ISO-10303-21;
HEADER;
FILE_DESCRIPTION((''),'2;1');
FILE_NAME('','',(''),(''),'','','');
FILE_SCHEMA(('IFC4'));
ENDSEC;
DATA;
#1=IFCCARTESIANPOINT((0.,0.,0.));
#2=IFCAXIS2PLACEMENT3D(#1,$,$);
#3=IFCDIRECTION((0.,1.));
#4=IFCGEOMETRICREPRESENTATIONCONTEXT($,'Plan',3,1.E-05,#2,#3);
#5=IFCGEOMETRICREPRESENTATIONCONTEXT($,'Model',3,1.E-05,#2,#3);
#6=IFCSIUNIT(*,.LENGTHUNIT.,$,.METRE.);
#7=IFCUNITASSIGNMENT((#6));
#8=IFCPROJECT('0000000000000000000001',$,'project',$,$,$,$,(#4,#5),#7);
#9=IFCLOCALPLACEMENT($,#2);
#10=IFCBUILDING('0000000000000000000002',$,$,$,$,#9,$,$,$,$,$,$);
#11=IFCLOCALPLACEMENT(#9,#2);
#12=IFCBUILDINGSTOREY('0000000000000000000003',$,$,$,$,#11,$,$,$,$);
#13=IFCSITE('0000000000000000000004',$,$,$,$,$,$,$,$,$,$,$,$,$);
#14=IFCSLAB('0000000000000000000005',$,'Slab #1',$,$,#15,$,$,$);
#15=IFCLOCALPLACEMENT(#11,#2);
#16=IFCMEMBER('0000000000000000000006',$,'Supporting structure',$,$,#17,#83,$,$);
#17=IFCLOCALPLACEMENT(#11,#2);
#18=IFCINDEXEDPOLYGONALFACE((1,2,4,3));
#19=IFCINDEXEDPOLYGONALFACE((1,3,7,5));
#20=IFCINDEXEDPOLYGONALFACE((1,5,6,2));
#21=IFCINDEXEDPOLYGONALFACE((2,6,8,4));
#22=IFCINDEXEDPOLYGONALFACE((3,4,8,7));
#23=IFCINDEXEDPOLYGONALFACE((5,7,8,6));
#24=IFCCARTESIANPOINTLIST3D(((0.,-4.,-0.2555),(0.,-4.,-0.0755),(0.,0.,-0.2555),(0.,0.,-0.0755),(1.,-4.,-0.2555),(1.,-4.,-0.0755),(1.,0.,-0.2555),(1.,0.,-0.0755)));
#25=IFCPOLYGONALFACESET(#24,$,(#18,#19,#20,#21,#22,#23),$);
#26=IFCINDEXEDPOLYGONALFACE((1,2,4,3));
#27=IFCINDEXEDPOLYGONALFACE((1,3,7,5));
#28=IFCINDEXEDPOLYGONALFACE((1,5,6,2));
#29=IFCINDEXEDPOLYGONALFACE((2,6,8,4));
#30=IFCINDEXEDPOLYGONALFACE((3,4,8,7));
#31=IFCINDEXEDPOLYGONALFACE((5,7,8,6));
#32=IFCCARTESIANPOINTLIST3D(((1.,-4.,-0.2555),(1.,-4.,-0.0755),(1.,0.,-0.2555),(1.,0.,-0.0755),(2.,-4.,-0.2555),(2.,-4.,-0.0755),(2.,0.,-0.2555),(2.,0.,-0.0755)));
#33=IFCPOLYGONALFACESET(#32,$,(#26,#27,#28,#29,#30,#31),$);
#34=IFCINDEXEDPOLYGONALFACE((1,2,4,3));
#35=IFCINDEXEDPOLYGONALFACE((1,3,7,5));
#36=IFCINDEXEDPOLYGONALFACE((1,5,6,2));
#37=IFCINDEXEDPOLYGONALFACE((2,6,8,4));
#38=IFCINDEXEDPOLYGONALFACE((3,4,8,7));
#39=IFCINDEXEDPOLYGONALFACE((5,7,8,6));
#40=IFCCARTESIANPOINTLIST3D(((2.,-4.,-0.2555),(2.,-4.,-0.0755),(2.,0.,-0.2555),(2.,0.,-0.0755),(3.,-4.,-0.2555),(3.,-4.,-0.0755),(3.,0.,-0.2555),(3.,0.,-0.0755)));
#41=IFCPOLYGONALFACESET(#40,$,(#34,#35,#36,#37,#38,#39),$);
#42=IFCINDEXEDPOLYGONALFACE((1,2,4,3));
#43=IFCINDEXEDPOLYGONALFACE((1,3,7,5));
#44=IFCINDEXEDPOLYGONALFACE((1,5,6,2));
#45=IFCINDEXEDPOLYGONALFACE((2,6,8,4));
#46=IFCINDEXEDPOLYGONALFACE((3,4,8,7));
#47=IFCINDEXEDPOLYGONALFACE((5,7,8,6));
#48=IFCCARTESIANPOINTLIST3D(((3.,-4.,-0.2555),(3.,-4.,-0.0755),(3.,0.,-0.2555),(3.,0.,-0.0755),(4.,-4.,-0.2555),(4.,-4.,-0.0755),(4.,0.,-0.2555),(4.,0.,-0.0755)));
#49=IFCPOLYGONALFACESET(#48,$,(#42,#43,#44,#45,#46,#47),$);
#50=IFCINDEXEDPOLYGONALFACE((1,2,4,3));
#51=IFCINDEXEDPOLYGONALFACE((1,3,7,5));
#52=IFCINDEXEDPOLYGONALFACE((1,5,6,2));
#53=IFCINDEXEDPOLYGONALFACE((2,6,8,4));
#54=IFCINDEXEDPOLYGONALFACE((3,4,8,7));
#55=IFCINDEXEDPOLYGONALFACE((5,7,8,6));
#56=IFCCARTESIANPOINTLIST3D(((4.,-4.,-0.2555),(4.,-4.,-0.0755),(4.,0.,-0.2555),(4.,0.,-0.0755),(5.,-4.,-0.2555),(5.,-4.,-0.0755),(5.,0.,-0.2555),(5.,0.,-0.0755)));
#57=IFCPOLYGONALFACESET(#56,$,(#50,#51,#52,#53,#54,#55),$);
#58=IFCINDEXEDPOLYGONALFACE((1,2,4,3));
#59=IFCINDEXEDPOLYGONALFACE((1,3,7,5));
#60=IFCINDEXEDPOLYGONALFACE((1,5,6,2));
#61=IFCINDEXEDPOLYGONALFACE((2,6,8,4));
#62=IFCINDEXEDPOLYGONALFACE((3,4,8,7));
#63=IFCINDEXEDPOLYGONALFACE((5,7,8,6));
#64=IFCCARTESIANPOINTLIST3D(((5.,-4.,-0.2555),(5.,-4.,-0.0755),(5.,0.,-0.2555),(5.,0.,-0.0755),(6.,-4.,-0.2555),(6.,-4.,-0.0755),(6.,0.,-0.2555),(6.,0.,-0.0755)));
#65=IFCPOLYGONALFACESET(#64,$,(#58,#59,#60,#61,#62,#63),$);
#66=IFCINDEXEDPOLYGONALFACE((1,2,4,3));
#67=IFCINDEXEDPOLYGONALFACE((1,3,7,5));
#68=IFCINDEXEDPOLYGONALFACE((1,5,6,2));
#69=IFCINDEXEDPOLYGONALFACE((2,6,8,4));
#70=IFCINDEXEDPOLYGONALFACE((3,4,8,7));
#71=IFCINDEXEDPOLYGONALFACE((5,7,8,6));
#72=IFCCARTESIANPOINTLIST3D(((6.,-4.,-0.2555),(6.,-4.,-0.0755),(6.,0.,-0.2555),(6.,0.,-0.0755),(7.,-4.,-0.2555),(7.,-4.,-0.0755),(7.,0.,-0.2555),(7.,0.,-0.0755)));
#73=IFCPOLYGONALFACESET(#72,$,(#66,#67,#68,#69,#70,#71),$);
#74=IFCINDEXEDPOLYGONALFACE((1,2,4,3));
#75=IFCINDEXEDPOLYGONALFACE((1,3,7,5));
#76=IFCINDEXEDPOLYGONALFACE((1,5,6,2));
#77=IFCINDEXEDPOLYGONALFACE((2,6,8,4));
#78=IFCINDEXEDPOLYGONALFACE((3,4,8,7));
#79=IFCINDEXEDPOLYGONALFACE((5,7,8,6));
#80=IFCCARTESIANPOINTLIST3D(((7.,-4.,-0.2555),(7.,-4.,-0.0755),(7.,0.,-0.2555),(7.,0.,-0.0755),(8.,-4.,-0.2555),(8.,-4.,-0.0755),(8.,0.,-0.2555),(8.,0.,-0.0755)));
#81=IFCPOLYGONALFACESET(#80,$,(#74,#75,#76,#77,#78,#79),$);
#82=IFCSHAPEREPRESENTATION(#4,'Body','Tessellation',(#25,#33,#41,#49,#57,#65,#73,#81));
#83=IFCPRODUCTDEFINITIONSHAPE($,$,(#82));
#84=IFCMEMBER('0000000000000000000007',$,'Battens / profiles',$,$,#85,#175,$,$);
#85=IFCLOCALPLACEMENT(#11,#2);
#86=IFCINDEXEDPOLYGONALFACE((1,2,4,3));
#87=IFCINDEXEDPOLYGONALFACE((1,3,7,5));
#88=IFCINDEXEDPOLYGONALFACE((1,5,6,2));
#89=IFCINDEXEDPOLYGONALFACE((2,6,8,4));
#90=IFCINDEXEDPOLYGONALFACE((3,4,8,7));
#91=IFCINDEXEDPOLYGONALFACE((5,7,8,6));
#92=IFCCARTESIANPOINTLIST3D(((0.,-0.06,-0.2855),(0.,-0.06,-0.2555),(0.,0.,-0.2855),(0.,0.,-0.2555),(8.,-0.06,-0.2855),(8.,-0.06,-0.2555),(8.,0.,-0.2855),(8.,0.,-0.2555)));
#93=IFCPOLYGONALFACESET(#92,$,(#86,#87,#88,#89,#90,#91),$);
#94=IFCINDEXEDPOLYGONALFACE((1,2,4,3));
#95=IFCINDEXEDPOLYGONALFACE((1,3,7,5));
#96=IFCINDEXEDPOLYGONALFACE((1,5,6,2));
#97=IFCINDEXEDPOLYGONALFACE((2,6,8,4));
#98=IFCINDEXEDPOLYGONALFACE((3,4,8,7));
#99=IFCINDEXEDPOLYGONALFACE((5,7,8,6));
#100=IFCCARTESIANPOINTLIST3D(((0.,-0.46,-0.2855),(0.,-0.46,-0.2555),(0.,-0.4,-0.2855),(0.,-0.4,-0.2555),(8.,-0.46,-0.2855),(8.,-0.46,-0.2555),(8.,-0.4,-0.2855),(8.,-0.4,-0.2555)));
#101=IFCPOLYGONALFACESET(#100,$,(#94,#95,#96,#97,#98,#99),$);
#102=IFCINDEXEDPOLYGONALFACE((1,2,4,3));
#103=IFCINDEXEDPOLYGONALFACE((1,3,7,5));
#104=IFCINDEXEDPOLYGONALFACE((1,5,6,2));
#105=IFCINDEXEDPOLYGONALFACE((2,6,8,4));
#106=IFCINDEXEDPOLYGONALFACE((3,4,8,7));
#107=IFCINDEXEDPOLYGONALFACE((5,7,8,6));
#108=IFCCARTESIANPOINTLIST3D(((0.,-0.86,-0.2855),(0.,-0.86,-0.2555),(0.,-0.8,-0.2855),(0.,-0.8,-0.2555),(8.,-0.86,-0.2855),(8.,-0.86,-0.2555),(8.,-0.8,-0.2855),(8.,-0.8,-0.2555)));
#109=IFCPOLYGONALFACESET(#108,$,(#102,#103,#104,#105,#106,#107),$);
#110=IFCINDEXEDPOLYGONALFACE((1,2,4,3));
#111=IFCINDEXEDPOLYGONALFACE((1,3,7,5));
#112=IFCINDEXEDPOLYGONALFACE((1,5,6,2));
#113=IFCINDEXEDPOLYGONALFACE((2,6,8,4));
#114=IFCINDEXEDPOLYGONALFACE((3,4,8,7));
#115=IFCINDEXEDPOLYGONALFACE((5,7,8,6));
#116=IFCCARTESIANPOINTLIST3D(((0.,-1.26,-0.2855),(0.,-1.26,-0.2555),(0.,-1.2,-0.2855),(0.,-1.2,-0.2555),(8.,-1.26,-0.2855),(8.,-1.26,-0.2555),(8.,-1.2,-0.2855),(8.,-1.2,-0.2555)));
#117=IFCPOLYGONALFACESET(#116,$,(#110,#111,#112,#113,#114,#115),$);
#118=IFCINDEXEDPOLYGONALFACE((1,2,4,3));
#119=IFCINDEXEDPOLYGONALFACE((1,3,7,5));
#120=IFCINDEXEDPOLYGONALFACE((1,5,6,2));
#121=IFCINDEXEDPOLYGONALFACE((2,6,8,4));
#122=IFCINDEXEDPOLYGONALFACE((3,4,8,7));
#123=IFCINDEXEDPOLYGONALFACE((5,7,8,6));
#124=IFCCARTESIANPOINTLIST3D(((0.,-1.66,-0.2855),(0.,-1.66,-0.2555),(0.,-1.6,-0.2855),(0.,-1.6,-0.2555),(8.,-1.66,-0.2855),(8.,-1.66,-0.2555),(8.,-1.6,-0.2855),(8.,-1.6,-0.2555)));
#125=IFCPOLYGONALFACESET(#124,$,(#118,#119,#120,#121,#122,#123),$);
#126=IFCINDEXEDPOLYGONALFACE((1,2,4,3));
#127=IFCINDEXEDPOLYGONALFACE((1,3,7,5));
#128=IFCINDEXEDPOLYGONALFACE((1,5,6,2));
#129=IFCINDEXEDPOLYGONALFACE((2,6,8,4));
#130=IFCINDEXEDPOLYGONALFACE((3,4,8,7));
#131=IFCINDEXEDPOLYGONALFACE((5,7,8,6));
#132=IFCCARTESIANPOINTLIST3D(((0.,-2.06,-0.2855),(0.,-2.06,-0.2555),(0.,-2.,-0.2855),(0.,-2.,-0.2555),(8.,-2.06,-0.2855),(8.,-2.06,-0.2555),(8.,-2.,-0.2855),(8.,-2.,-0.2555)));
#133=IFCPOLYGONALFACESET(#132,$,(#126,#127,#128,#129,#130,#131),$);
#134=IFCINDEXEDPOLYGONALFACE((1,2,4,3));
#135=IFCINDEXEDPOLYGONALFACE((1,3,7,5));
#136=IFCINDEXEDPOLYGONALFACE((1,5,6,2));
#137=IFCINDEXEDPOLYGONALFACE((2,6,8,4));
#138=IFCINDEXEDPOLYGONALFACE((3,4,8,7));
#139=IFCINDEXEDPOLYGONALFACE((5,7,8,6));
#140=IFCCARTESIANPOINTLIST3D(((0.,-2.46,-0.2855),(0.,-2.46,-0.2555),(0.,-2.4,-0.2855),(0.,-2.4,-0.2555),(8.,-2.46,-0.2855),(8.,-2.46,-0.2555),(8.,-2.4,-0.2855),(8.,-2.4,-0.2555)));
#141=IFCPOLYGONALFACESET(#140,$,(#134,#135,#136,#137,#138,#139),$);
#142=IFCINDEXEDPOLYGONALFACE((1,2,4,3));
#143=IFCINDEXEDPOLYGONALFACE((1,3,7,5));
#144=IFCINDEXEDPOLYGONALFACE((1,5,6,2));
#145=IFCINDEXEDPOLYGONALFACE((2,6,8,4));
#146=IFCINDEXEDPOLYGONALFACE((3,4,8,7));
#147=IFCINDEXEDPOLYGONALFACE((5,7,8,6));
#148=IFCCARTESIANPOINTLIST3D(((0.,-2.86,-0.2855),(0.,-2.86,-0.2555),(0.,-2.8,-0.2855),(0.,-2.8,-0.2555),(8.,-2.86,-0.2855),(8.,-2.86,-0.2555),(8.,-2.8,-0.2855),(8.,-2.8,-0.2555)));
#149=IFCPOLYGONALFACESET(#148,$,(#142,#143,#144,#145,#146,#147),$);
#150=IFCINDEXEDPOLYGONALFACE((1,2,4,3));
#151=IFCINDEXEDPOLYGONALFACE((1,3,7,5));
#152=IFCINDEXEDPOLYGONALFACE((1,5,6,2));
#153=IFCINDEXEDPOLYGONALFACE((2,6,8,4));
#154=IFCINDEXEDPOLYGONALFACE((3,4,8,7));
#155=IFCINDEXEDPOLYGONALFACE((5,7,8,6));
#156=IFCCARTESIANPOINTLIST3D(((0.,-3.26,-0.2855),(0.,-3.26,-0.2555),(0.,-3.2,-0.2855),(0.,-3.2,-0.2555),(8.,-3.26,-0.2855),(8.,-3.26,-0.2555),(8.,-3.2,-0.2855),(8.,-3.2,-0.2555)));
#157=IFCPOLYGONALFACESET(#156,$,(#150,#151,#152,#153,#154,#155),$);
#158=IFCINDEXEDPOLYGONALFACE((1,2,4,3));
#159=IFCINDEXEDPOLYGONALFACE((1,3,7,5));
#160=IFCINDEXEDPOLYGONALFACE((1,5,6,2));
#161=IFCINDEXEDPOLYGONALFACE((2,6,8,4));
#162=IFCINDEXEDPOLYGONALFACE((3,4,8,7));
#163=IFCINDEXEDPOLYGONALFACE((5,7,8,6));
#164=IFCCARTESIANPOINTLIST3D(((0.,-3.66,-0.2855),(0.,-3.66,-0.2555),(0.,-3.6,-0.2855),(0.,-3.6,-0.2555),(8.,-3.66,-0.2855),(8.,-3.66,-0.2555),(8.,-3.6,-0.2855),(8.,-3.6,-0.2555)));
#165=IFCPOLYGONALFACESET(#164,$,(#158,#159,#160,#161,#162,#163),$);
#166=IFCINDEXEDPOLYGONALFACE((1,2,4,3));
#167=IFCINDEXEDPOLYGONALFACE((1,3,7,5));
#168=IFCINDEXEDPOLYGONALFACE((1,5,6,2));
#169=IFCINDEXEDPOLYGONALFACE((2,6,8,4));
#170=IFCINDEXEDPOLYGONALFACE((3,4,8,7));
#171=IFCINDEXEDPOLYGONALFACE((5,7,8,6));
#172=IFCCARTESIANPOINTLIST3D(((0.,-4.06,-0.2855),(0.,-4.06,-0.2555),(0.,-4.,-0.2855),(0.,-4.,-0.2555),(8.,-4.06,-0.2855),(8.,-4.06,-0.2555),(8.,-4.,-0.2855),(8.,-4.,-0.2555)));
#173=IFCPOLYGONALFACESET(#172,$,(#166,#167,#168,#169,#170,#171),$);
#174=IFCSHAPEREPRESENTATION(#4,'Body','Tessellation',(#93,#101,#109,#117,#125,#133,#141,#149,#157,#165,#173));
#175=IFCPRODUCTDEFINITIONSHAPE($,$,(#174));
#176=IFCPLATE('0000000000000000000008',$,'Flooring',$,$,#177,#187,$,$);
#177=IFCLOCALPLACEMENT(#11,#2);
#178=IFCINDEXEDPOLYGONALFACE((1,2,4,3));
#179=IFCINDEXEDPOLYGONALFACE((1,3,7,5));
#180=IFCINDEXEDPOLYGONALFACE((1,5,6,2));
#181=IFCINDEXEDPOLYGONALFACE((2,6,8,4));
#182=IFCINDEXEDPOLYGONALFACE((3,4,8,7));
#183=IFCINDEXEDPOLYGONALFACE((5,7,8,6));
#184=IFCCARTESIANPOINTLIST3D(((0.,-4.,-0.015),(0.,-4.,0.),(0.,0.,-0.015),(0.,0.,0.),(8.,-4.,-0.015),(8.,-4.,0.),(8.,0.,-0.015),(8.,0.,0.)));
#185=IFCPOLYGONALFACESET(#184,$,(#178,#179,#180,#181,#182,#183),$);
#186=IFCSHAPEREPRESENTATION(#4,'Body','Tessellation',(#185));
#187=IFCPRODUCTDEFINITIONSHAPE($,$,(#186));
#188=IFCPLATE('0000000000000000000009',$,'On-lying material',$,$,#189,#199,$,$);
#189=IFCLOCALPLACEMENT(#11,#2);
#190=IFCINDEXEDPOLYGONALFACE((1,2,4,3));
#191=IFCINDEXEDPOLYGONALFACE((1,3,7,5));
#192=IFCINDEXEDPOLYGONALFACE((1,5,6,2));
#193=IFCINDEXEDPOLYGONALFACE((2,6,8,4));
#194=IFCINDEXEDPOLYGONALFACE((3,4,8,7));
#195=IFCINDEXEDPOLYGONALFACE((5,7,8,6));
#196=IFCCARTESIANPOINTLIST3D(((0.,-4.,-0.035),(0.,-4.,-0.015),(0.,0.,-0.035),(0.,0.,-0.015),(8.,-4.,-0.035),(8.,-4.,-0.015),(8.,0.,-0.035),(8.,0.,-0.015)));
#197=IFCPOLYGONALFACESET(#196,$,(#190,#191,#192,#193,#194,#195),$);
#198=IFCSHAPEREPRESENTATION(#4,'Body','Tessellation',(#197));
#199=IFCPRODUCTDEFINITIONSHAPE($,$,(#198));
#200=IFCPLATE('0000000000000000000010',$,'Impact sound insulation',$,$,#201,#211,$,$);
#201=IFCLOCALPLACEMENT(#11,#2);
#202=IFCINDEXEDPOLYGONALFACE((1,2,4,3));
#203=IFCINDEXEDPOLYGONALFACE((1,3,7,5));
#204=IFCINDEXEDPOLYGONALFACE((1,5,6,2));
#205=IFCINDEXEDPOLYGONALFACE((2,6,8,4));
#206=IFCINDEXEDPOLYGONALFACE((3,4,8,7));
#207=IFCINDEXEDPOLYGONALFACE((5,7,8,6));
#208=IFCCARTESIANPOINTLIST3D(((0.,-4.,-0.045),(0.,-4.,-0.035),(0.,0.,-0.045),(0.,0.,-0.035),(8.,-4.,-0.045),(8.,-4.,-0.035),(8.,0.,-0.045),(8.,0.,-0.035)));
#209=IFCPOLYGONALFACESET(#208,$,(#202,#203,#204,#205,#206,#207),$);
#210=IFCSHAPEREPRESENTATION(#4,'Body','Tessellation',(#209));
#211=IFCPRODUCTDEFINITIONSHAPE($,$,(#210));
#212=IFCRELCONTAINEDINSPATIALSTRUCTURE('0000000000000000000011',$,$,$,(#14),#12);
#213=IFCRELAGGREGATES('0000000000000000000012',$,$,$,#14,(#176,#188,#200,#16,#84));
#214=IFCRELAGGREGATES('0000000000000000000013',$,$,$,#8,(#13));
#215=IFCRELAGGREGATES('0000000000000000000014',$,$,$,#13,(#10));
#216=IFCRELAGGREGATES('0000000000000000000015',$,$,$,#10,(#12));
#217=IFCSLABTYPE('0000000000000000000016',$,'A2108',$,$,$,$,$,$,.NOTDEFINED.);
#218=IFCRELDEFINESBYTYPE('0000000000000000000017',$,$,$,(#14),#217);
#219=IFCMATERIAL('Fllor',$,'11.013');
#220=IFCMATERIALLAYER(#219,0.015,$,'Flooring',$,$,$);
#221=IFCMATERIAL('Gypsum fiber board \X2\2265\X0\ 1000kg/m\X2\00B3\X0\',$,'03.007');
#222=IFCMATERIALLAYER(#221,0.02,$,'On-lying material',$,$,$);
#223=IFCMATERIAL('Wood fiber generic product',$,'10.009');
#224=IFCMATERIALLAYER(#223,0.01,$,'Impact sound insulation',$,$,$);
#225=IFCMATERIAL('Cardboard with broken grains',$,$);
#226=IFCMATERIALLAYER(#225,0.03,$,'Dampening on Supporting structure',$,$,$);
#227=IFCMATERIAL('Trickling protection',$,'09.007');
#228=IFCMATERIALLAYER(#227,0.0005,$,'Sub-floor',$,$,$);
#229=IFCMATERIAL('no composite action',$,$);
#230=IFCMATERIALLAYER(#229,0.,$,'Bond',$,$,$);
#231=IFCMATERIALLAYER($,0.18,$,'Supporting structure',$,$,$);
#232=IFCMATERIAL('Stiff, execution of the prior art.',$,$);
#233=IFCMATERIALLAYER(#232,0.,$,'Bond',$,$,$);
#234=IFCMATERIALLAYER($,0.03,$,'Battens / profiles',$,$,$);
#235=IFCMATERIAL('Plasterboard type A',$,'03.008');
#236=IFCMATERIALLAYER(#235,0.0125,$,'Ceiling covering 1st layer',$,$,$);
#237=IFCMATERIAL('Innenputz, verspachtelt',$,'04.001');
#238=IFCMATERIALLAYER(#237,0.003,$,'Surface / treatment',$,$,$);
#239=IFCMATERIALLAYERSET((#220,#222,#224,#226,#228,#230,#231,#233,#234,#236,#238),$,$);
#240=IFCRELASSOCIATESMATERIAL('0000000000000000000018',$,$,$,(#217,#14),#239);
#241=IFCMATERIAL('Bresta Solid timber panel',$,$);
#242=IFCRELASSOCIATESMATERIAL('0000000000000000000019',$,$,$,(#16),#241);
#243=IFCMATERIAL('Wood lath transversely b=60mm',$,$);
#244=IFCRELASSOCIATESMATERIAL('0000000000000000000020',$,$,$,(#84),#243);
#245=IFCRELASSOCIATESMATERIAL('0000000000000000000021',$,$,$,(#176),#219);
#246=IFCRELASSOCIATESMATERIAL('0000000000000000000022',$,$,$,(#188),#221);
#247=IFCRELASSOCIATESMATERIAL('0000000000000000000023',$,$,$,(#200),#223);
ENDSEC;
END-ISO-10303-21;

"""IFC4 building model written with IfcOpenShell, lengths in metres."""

from ifc_helpers import new_model, si_unit, direction, frame, frame_2d, origin, origin_with_axes, place, context, project, spatial, rectangle, extrude, material, layer, layer_set, type_object, element, aggregate, save


model = new_model("IFC4")

# Units and contexts
plan_context = context("Plan", 3, precision=1e-05, world=origin(), true_north=direction((0.0, 1.0)))
model_context = context("Model", 3, precision=1e-05, world=origin(), true_north=direction((0.0, 1.0)))
ifc_project = project(units=[si_unit("LENGTHUNIT", "METRE")], contexts=[plan_context, model_context])

# Site, building, storey
site = spatial("IfcSite", under=ifc_project)
building_placement = place(None, origin())
building = spatial("IfcBuilding", under=site, at=building_placement)
storey_placement = place(building_placement, origin())
storey = spatial("IfcBuildingStorey", under=building, at=storey_placement)

# Slab, members, plates
ifc_material_1 = material(Name="Fllor", Category="11.013")
ifc_layer_1 = layer(ifc_material_1, 0.015, Name="Flooring")
ifc_material_2 = material(Name="Gypsum fiber board ≥ 1000kg/m³", Category="03.007")
ifc_layer_2 = layer(ifc_material_2, 0.02, Name="On-lying material")
ifc_material_3 = material(Name="Wood fiber generic product", Category="10.009")
ifc_layer_3 = layer(ifc_material_3, 0.01, Name="Impact sound insulation")
ifc_material_4 = material(Name="Cardboard with broken grains")
ifc_layer_4 = layer(ifc_material_4, 0.03, Name="Dampening on Supporting structure")
ifc_material_5 = material(Name="Trickling protection", Category="09.007")
ifc_layer_5 = layer(ifc_material_5, 0.0005, Name="Sub-floor")
ifc_material_6 = material(Name="no composite action")
ifc_layer_6 = layer(ifc_material_6, 0.0, Name="Bond")
ifc_layer_7 = layer(None, 0.18, Name="Supporting structure")
ifc_material_7 = material(Name="Stiff, execution of the prior art.")
ifc_layer_8 = layer(ifc_material_7, 0.0, Name="Bond")
ifc_layer_9 = layer(None, 0.03, Name="Battens / profiles")
ifc_material_8 = material(Name="Plasterboard type A", Category="03.008")
ifc_layer_10 = layer(ifc_material_8, 0.0125, Name="Ceiling covering 1st layer")
ifc_material_9 = material(Name="Innenputz, verspachtelt", Category="04.001")
ifc_layer_11 = layer(ifc_material_9, 0.003, Name="Surface / treatment")
ifc_layer_set = layer_set([ifc_layer_1, ifc_layer_2, ifc_layer_3, ifc_layer_4, ifc_layer_5, ifc_layer_6, ifc_layer_7, ifc_layer_8, ifc_layer_9, ifc_layer_10, ifc_layer_11])
slab_type = type_object("IfcSlabType", Name="A2108", PredefinedType="NOTDEFINED", material=ifc_layer_set)
slab_placement = place(None, frame((0.0, 0.0, 0.0), z_axis=(0.0, 0.0, -1.0), x_axis=(1.0, 0.0, 0.0)))
slab = element("IfcSlab", 1, at=slab_placement, inside=storey, type_object=slab_type, material=ifc_layer_set, Name="Slab #1")
ifc_material_10 = material(Name="Bresta Solid timber panel")
member_1_placement = place(slab_placement, origin())
member_1 = element("IfcMember", 2, at=member_1_placement, material=ifc_material_10, Name="Supporting structure", context=plan_context, shape_type="SweptSolid", body=[
    extrude(rectangle(XDim=1.0, YDim=0.18, at=frame_2d((0.5, 0.09), x_axis=(1.0, 0.0))), frame((0.0, 4.0, 0.0755), z_axis=(0.0, -1.0, 0.0), x_axis=(1.0, 0.0, 0.0)), (0.0, 0.0, 1.0), 4.0),
    extrude(rectangle(XDim=1.0, YDim=0.18, at=frame_2d((0.5, 0.09), x_axis=(1.0, 0.0))), frame((1.0, 4.0, 0.0755), z_axis=(0.0, -1.0, 0.0), x_axis=(1.0, 0.0, 0.0)), (0.0, 0.0, 1.0), 4.0),
    extrude(rectangle(XDim=1.0, YDim=0.18, at=frame_2d((0.5, 0.09), x_axis=(1.0, 0.0))), frame((2.0, 4.0, 0.0755), z_axis=(0.0, -1.0, 0.0), x_axis=(1.0, 0.0, 0.0)), (0.0, 0.0, 1.0), 4.0),
    extrude(rectangle(XDim=1.0, YDim=0.18, at=frame_2d((0.5, 0.09), x_axis=(1.0, 0.0))), frame((3.0, 4.0, 0.0755), z_axis=(0.0, -1.0, 0.0), x_axis=(1.0, 0.0, 0.0)), (0.0, 0.0, 1.0), 4.0),
    extrude(rectangle(XDim=1.0, YDim=0.18, at=frame_2d((0.5, 0.09), x_axis=(1.0, 0.0))), frame((4.0, 4.0, 0.0755), z_axis=(0.0, -1.0, 0.0), x_axis=(1.0, 0.0, 0.0)), (0.0, 0.0, 1.0), 4.0),
    extrude(rectangle(XDim=1.0, YDim=0.18, at=frame_2d((0.5, 0.09), x_axis=(1.0, 0.0))), frame((5.0, 4.0, 0.0755), z_axis=(0.0, -1.0, 0.0), x_axis=(1.0, 0.0, 0.0)), (0.0, 0.0, 1.0), 4.0),
    extrude(rectangle(XDim=1.0, YDim=0.18, at=frame_2d((0.5, 0.09), x_axis=(1.0, 0.0))), frame((6.0, 4.0, 0.0755), z_axis=(0.0, -1.0, 0.0), x_axis=(1.0, 0.0, 0.0)), (0.0, 0.0, 1.0), 4.0),
    extrude(rectangle(XDim=1.0, YDim=0.18, at=frame_2d((0.5, 0.09), x_axis=(1.0, 0.0))), frame((7.0, 4.0, 0.0755), z_axis=(0.0, -1.0, 0.0), x_axis=(1.0, 0.0, 0.0)), (0.0, 0.0, 1.0), 4.0),
])
ifc_material_11 = material(Name="Wood lath transversely b=60mm")
member_2_placement = place(slab_placement, origin())
member_2 = element("IfcMember", 3, at=member_2_placement, material=ifc_material_11, Name="Battens / profiles", context=plan_context, shape_type="SweptSolid", body=[
    extrude(rectangle(XDim=0.06, YDim=0.03, at=frame_2d((0.03, 0.015), x_axis=(1.0, 0.0))), frame((0.0, 0.0, 0.2555), z_axis=(1.0, 0.0, 0.0), x_axis=(0.0, 1.0, 0.0)), (0.0, 0.0, 1.0), 8.0),
    extrude(rectangle(XDim=0.06, YDim=0.03, at=frame_2d((0.03, 0.015), x_axis=(1.0, 0.0))), frame((0.0, 0.4, 0.2555), z_axis=(1.0, 0.0, 0.0), x_axis=(0.0, 1.0, 0.0)), (0.0, 0.0, 1.0), 8.0),
    extrude(rectangle(XDim=0.06, YDim=0.03, at=frame_2d((0.03, 0.015), x_axis=(1.0, 0.0))), frame((0.0, 0.8, 0.2555), z_axis=(1.0, 0.0, 0.0), x_axis=(0.0, 1.0, 0.0)), (0.0, 0.0, 1.0), 8.0),
    extrude(rectangle(XDim=0.06, YDim=0.03, at=frame_2d((0.03, 0.015), x_axis=(1.0, 0.0))), frame((0.0, 1.2, 0.2555), z_axis=(1.0, 0.0, 0.0), x_axis=(0.0, 1.0, 0.0)), (0.0, 0.0, 1.0), 8.0),
    extrude(rectangle(XDim=0.06, YDim=0.03, at=frame_2d((0.03, 0.015), x_axis=(1.0, 0.0))), frame((0.0, 1.6, 0.2555), z_axis=(1.0, 0.0, 0.0), x_axis=(0.0, 1.0, 0.0)), (0.0, 0.0, 1.0), 8.0),
    extrude(rectangle(XDim=0.06, YDim=0.03, at=frame_2d((0.03, 0.015), x_axis=(1.0, 0.0))), frame((0.0, 2.0, 0.2555), z_axis=(1.0, 0.0, 0.0), x_axis=(0.0, 1.0, 0.0)), (0.0, 0.0, 1.0), 8.0),
    extrude(rectangle(XDim=0.06, YDim=0.03, at=frame_2d((0.03, 0.015), x_axis=(1.0, 0.0))), frame((0.0, 2.4, 0.2555), z_axis=(1.0, 0.0, 0.0), x_axis=(0.0, 1.0, 0.0)), (0.0, 0.0, 1.0), 8.0),
    extrude(rectangle(XDim=0.06, YDim=0.03, at=frame_2d((0.03, 0.015), x_axis=(1.0, 0.0))), frame((0.0, 2.8, 0.2555), z_axis=(1.0, 0.0, 0.0), x_axis=(0.0, 1.0, 0.0)), (0.0, 0.0, 1.0), 8.0),
    extrude(rectangle(XDim=0.06, YDim=0.03, at=frame_2d((0.03, 0.015), x_axis=(1.0, 0.0))), frame((0.0, 3.2, 0.2555), z_axis=(1.0, 0.0, 0.0), x_axis=(0.0, 1.0, 0.0)), (0.0, 0.0, 1.0), 8.0),
    extrude(rectangle(XDim=0.06, YDim=0.03, at=frame_2d((0.03, 0.015), x_axis=(1.0, 0.0))), frame((0.0, 3.6, 0.2555), z_axis=(1.0, 0.0, 0.0), x_axis=(0.0, 1.0, 0.0)), (0.0, 0.0, 1.0), 8.0),
    extrude(rectangle(XDim=0.06, YDim=0.03, at=frame_2d((0.03, 0.015), x_axis=(1.0, 0.0))), frame((0.0, 4.0, 0.2555), z_axis=(1.0, 0.0, 0.0), x_axis=(0.0, 1.0, 0.0)), (0.0, 0.0, 1.0), 8.0),
])
plate_1_placement = place(slab_placement, origin())
plate_1 = element("IfcPlate", 4, at=plate_1_placement, material=ifc_material_1, Name="Flooring", context=plan_context, shape_type="SweptSolid", body=[
    extrude(rectangle(XDim=8.0, YDim=4.0, at=frame_2d((4.0, 2.0), x_axis=(1.0, 0.0))), origin_with_axes(), (0.0, 0.0, 1.0), 0.015),
])
plate_2_placement = place(slab_placement, origin())
plate_2 = element("IfcPlate", 5, at=plate_2_placement, material=ifc_material_2, Name="On-lying material", context=plan_context, shape_type="SweptSolid", body=[
    extrude(rectangle(XDim=8.0, YDim=4.0, at=frame_2d((4.0, 2.0), x_axis=(1.0, 0.0))), frame((0.0, 0.0, 0.015), z_axis=(0.0, 0.0, 1.0), x_axis=(1.0, 0.0, 0.0)), (0.0, 0.0, 1.0), 0.02),
])
plate_3_placement = place(slab_placement, origin())
plate_3 = element("IfcPlate", 6, at=plate_3_placement, material=ifc_material_3, Name="Impact sound insulation", context=plan_context, shape_type="SweptSolid", body=[
    extrude(rectangle(XDim=8.0, YDim=4.0, at=frame_2d((4.0, 2.0), x_axis=(1.0, 0.0))), frame((0.0, 0.0, 0.035), z_axis=(0.0, 0.0, 1.0), x_axis=(1.0, 0.0, 0.0)), (0.0, 0.0, 1.0), 0.01),
])
aggregate(slab, [plate_1, plate_2, plate_3, member_1, member_2])

save(model, "model.ifc")
